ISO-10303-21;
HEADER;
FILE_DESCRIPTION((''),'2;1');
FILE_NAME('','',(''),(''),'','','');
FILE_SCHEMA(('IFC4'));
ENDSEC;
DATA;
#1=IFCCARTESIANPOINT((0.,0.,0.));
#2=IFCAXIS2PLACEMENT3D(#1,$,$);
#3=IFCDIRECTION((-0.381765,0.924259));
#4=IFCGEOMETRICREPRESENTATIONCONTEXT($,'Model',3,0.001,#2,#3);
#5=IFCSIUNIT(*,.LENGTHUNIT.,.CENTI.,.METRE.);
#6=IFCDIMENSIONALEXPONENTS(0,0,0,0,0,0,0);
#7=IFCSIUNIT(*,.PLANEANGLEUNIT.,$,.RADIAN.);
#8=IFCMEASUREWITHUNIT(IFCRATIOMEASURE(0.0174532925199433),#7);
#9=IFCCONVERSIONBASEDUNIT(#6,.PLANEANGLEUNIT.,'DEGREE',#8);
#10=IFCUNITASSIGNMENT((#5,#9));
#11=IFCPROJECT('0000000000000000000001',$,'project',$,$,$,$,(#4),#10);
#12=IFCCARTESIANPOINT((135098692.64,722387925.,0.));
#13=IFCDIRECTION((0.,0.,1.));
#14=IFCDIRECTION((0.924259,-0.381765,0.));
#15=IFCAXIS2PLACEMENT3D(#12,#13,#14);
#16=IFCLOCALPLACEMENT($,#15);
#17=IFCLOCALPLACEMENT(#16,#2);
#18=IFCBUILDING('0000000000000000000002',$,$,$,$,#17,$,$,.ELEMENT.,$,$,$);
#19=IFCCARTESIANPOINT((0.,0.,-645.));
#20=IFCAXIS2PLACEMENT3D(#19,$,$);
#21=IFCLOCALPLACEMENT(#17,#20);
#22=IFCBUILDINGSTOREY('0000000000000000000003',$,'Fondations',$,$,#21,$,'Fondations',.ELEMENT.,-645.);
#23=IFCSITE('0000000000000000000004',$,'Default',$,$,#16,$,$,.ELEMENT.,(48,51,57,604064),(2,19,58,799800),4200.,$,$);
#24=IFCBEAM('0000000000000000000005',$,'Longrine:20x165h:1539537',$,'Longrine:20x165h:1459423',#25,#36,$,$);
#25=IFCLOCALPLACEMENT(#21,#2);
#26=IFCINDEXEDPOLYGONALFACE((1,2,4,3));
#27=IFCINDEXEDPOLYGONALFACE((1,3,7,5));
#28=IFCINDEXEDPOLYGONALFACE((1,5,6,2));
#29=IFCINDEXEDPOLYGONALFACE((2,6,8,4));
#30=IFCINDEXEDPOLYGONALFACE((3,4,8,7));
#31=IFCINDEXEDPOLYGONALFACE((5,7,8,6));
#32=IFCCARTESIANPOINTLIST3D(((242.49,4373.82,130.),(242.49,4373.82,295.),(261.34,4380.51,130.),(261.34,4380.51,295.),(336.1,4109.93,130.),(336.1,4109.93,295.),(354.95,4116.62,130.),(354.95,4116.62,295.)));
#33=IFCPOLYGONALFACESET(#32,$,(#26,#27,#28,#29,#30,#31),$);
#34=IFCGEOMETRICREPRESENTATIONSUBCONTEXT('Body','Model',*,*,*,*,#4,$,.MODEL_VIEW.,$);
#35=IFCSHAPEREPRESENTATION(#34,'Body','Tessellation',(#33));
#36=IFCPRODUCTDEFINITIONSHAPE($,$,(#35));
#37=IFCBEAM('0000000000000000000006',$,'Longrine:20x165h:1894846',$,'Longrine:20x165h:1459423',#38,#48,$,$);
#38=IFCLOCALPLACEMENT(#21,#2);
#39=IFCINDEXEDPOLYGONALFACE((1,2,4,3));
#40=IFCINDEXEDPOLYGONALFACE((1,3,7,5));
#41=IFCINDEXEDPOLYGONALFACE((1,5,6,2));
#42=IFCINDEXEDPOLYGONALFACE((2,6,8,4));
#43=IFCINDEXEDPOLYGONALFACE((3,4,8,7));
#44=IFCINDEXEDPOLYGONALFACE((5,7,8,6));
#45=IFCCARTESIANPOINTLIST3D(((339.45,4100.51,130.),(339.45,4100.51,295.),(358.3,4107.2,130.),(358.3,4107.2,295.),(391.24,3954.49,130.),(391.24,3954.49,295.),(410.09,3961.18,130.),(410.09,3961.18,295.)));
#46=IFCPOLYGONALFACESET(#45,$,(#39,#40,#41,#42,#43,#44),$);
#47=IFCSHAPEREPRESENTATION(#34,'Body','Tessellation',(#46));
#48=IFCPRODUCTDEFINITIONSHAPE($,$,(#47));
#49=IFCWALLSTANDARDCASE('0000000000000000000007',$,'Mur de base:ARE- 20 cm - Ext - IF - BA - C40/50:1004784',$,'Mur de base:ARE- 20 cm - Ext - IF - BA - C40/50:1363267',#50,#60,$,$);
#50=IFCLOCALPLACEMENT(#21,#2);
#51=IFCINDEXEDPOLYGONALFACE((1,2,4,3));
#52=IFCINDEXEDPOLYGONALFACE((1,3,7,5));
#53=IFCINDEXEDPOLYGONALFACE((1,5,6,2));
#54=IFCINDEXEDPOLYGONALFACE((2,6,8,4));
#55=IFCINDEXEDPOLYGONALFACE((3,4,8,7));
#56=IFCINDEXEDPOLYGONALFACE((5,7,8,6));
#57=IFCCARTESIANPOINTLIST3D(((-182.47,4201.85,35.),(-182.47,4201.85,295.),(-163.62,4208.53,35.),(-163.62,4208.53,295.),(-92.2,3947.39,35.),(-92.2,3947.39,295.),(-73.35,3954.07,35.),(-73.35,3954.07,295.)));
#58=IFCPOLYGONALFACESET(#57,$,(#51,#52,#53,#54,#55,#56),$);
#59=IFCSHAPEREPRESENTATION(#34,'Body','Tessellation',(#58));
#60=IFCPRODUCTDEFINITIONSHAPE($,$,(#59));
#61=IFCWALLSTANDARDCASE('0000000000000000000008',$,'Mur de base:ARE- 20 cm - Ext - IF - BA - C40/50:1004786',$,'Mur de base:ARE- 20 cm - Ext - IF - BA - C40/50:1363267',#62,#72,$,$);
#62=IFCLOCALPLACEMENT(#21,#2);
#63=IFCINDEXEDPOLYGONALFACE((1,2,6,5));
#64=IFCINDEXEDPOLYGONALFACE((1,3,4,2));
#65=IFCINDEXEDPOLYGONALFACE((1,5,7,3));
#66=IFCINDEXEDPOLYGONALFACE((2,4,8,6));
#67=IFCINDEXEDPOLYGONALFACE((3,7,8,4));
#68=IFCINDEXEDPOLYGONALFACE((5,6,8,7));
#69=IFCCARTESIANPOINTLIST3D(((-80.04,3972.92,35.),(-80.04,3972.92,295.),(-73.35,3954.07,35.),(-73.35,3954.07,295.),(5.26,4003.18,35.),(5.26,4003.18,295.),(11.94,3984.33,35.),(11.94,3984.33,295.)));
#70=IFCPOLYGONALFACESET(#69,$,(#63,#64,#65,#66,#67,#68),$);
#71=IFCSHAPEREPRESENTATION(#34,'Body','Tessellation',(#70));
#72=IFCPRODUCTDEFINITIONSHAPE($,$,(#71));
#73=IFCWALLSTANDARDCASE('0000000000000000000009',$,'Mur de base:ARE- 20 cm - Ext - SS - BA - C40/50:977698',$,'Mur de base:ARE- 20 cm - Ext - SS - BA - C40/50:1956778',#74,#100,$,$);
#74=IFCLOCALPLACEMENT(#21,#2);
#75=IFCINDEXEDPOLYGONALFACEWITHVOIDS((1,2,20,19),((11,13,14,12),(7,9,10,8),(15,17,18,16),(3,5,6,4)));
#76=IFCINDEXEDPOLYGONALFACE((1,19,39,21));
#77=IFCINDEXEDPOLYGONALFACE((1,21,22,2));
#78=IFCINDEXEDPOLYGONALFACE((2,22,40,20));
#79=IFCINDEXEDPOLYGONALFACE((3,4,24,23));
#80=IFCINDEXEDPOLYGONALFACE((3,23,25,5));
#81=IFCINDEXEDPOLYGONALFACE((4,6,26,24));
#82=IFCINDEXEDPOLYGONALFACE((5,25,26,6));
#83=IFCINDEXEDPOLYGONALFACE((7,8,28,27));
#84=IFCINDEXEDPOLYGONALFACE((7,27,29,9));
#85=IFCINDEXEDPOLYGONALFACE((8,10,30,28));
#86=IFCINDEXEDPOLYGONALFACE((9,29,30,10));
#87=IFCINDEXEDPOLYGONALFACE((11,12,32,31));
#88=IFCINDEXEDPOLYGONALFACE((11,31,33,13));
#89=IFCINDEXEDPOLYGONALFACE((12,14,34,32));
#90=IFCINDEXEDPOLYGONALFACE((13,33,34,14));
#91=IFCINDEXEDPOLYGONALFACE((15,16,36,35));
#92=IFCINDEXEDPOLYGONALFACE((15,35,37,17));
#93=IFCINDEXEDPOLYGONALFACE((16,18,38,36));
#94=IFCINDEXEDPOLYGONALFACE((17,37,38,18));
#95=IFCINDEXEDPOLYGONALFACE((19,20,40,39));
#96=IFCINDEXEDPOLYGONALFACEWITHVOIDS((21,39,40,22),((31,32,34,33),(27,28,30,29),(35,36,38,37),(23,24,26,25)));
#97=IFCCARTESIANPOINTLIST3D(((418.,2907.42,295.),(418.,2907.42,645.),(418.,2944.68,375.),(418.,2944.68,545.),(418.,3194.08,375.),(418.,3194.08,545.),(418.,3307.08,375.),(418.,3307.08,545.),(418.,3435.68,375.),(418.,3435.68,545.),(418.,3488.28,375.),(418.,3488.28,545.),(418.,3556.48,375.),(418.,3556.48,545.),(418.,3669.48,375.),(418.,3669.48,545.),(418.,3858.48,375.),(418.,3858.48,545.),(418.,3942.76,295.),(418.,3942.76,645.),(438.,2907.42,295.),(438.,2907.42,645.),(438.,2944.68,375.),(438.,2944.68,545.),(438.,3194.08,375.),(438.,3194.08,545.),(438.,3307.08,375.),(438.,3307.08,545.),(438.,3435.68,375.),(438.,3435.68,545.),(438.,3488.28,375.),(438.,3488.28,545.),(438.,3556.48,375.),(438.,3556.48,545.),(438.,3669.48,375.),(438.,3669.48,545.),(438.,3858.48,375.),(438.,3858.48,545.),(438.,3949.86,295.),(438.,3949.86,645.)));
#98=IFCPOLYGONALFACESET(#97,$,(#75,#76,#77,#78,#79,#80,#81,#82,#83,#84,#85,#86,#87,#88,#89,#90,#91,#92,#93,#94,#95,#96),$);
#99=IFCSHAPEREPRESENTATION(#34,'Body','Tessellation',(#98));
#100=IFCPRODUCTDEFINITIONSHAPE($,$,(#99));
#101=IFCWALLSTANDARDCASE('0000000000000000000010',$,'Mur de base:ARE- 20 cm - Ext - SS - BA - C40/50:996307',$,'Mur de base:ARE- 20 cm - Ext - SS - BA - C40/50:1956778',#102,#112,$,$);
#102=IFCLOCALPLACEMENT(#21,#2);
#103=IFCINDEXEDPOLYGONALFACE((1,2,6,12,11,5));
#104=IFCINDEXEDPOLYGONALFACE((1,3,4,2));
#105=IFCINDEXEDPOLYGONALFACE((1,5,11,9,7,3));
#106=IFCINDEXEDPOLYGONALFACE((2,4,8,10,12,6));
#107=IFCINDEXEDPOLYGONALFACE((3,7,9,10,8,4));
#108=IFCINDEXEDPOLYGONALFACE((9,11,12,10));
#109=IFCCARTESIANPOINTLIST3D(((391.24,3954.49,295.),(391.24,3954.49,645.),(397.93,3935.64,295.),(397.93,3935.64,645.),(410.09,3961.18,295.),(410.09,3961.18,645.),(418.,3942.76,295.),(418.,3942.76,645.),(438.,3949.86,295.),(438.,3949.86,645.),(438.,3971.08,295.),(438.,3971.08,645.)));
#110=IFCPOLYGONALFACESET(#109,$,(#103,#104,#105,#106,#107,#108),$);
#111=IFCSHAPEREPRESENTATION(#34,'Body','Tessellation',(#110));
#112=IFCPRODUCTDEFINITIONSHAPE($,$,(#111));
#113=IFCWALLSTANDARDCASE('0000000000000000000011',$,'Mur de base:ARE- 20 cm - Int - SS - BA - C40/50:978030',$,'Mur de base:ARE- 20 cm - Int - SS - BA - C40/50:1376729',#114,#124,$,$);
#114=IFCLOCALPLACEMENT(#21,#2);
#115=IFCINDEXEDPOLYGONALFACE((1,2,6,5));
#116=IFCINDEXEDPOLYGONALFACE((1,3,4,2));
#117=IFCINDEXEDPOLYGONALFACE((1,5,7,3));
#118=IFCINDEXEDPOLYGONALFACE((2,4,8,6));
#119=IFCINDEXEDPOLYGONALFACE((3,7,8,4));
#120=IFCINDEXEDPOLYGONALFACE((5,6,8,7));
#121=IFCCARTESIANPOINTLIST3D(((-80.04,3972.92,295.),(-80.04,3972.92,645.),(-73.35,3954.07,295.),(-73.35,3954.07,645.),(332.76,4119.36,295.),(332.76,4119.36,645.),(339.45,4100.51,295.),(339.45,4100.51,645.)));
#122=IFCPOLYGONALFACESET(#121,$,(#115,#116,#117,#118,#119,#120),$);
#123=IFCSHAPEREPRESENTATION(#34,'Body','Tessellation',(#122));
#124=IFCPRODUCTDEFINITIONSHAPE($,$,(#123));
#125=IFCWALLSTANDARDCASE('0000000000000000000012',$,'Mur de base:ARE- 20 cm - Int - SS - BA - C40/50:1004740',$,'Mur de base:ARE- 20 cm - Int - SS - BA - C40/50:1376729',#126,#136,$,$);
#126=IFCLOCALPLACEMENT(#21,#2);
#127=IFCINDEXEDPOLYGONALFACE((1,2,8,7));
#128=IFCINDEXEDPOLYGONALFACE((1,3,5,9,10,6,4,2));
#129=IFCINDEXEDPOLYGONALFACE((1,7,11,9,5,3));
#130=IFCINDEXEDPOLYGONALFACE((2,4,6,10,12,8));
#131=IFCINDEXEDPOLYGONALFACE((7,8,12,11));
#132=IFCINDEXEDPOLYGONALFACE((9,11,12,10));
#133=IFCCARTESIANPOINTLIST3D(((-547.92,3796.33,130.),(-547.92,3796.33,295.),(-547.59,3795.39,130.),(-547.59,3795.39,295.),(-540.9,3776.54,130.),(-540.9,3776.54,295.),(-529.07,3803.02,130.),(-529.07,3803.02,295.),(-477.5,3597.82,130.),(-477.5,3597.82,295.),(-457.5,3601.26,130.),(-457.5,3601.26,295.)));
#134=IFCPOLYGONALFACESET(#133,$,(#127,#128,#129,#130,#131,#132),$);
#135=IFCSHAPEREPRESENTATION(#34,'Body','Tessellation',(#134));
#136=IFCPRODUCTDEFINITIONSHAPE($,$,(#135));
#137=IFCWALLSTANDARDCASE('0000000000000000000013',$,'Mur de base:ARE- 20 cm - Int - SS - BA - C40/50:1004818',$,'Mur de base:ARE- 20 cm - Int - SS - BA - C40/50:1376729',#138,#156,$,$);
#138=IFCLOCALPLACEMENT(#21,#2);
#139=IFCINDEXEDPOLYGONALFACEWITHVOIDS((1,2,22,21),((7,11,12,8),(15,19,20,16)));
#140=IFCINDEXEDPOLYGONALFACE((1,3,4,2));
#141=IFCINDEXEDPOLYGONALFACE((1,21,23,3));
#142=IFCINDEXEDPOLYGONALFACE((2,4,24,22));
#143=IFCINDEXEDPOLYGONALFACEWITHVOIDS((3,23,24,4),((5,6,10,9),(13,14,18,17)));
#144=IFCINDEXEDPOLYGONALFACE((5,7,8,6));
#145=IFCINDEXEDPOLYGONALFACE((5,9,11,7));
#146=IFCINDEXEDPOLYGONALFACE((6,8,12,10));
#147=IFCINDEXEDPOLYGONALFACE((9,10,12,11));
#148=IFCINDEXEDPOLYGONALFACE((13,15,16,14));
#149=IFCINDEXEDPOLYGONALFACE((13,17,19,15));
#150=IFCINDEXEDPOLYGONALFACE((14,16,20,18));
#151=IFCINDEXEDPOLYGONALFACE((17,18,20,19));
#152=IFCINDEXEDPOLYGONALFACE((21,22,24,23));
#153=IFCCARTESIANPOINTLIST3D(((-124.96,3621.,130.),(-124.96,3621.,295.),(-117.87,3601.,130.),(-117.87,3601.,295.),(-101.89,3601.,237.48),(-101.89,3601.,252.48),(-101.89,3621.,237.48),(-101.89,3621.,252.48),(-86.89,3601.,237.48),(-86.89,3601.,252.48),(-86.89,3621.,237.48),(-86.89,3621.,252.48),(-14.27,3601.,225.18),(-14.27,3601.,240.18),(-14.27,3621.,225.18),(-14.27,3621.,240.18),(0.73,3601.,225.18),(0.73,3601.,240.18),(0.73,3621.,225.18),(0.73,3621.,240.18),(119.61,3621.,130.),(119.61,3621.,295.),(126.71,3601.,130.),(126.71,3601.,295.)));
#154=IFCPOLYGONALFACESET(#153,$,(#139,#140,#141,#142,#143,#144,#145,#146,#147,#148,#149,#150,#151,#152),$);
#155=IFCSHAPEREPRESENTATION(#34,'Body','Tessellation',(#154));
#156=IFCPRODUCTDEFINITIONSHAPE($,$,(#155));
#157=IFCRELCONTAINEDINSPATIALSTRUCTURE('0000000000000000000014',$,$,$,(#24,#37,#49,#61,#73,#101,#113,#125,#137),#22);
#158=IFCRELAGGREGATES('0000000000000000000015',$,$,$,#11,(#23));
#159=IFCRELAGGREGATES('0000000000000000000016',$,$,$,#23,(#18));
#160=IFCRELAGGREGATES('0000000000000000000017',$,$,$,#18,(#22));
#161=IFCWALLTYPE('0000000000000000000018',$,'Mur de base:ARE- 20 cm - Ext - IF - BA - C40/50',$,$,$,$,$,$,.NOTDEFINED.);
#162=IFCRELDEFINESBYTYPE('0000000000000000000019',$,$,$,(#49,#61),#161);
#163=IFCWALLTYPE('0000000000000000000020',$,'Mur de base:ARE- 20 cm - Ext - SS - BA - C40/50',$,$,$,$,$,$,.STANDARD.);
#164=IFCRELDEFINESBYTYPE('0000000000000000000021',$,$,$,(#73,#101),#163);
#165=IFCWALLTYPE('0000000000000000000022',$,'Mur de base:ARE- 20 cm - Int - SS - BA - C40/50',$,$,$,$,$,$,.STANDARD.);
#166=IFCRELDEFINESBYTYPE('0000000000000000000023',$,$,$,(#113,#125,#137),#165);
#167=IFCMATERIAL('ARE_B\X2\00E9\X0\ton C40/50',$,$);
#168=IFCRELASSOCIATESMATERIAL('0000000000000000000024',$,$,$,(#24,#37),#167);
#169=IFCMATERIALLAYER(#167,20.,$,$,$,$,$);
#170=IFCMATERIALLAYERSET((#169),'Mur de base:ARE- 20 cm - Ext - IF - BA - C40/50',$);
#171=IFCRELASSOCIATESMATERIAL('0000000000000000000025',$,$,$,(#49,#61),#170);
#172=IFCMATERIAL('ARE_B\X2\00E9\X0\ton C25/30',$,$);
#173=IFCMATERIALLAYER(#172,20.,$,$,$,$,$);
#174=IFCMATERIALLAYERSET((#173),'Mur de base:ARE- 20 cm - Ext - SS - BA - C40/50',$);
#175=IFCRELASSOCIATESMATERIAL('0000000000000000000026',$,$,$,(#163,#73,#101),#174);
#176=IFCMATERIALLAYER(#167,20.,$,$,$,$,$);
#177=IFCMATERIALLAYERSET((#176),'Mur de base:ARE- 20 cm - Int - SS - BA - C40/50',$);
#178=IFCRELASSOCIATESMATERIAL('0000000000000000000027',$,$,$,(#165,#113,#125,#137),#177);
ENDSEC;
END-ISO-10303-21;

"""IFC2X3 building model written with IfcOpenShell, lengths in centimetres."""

from ifc_helpers import new_model, entity, si_unit, converted_unit, direction, frame, frame_2d, origin, place, context, subcontext, project, spatial, polyline, rectangle, outline, extrude, material, layer, layer_set, layer_usage, type_object, element, save


model = new_model("IFC2X3")

# Units and contexts
model_context = context("Model", 3, precision=0.001, world=origin(), true_north=direction((-0.381765, 0.924259)))
body_context = subcontext(model_context, "Body", "Model", "MODEL_VIEW")
ifc_project = project(units=[si_unit("LENGTHUNIT", "METRE", prefix="CENTI"), converted_unit("PLANEANGLEUNIT", "DEGREE", entity("IfcRatioMeasure", 0.0174532925199433), si_unit("PLANEANGLEUNIT", "RADIAN"), dimensions=[0, 0, 0, 0, 0, 0, 0])], contexts=[model_context])

# Site, building, storey
site_placement = place(None, frame((135098692.64, 722387925.0, 0.0), z_axis=(0.0, 0.0, 1.0), x_axis=(0.924259, -0.381765, 0.0)))
site = spatial("IfcSite", under=ifc_project, at=site_placement, Name="Default", CompositionType="ELEMENT", RefLatitude=(48, 51, 57, 604064), RefLongitude=(2, 19, 58, 799800), RefElevation=4200.0)
building_placement = place(site_placement, origin())
building = spatial("IfcBuilding", under=site, at=building_placement, CompositionType="ELEMENT")
storey_placement = place(building_placement, frame((0.0, 0.0, -645.0)))
storey = spatial("IfcBuildingStorey", under=building, at=storey_placement, Name="Fondations", LongName="Fondations", CompositionType="ELEMENT", Elevation=-645.0)

# Beams
ifc_material_1 = material(Name="ARE_Béton C40/50")
beam_1_placement = place(storey_placement, frame((345.53, 4113.28, 295.0), z_axis=(0.0, 0.0, 1.0), x_axis=(-0.334331, 0.942456, 0.0)))
element("IfcBeam", 1, at=beam_1_placement, inside=storey, material=ifc_material_1, Name="Longrine:20x165h:1539537", ObjectType="Longrine:20x165h:1459423", context=body_context, shape_type="SweptSolid", body=[
    extrude(rectangle(XDim=165.0, YDim=20.0, at=frame_2d((0.0, 0.0), x_axis=(1.0, 0.0))), frame((0.0, 0.0, -82.5), z_axis=(1.0, 0.0, 0.0), x_axis=(0.0, 0.0, -1.0)), (0.0, 0.0, 1.0), 280.0),
])
beam_2_placement = place(storey_placement, frame((345.53, 4113.28, 295.0), z_axis=(0.0, 0.0, 1.0), x_axis=(0.334331, -0.942456, 0.0)))
element("IfcBeam", 2, at=beam_2_placement, inside=storey, material=ifc_material_1, Name="Longrine:20x165h:1894846", ObjectType="Longrine:20x165h:1459423", context=body_context, shape_type="SweptSolid", body=[
    extrude(rectangle(XDim=165.0, YDim=20.0, at=frame_2d((0.0, 0.0), x_axis=(1.0, 0.0))), frame((10.0, 0.0, -82.5), z_axis=(1.0, 0.0, 0.0), x_axis=(0.0, 0.0, -1.0)), (0.0, 0.0, 1.0), 154.93),
])

# Walls
ifc_layer_1 = layer(ifc_material_1, 20.0)
ifc_layer_set_1 = layer_set([ifc_layer_1], Name="Mur de base:ARE- 20 cm - Ext - IF - BA - C40/50")
ifc_layer_usage_1 = layer_usage(ifc_layer_set_1, "AXIS2", "NEGATIVE", 10.0)
wall_type_1 = type_object("IfcWallType", Name="Mur de base:ARE- 20 cm - Ext - IF - BA - C40/50", PredefinedType="NOTDEFINED")
wall_1_placement = place(storey_placement, frame((-82.77, 3950.73, 35.0), z_axis=(0.0, 0.0, 1.0), x_axis=(-0.334331, 0.942456, 0.0)))
element("IfcWallStandardCase", 3, at=wall_1_placement, inside=storey, type_object=wall_type_1, material=ifc_layer_usage_1, Name="Mur de base:ARE- 20 cm - Ext - IF - BA - C40/50:1004784", ObjectType="Mur de base:ARE- 20 cm - Ext - IF - BA - C40/50:1363267", context=body_context, shape_type="SweptSolid", body=[
    extrude(rectangle(XDim=270.0, YDim=20.0, at=frame_2d((135.0, 0.0), x_axis=(-1.0, 0.0))), origin(), (0.0, 0.0, 1.0), 260.0),
])
ifc_layer_usage_2 = layer_usage(ifc_layer_set_1, "AXIS2", "NEGATIVE", 10.0)
wall_2_placement = place(storey_placement, frame((8.6, 3993.75, 35.0), z_axis=(0.0, 0.0, 1.0), x_axis=(-0.942456, -0.334331, 0.0)))
element("IfcWallStandardCase", 4, at=wall_2_placement, inside=storey, type_object=wall_type_1, material=ifc_layer_usage_2, Name="Mur de base:ARE- 20 cm - Ext - IF - BA - C40/50:1004786", ObjectType="Mur de base:ARE- 20 cm - Ext - IF - BA - C40/50:1363267", context=body_context, shape_type="SweptSolid", body=[
    extrude(rectangle(XDim=90.5, YDim=20.0, at=frame_2d((45.25, 0.0), x_axis=(-1.0, 0.0))), origin(), (0.0, 0.0, 1.0), 260.0),
])

# Wall, openings
ifc_material_2 = material(Name="ARE_Béton C25/30")
ifc_layer_2 = layer(ifc_material_2, 20.0)
ifc_layer_set_2 = layer_set([ifc_layer_2], Name="Mur de base:ARE- 20 cm - Ext - SS - BA - C40/50")
ifc_layer_usage_3 = layer_usage(ifc_layer_set_2, "AXIS2", "NEGATIVE", 10.0)
wall_type_2 = type_object("IfcWallType", Name="Mur de base:ARE- 20 cm - Ext - SS - BA - C40/50", PredefinedType="STANDARD", material=ifc_layer_set_2)
wall_3_placement = place(storey_placement, frame((428.0, 3949.86, 295.0), z_axis=(0.0, 0.0, 1.0), x_axis=(0.0, -1.0, 0.0)))
wall_3 = element("IfcWallStandardCase", 5, at=wall_3_placement, inside=storey, type_object=wall_type_2, material=ifc_layer_usage_3, Name="Mur de base:ARE- 20 cm - Ext - SS - BA - C40/50:977698", ObjectType="Mur de base:ARE- 20 cm - Ext - SS - BA - C40/50:1956778", context=body_context, shape_type="SweptSolid", body=[
    extrude(outline(polyline([(1042.44, -10.0), (1042.44, 10.0), (0.0, 10.0), (7.09, -10.0), (1042.44, -10.0)])), origin(), (0.0, 0.0, 1.0), 350.0),
])
opening_1_placement = place(wall_3_placement, frame((3949.86, -428.0, -295.0), z_axis=(0.0, 0.0, 1.0), x_axis=(0.0, 1.0, 0.0)))
element("IfcOpeningElement", 6, at=opening_1_placement, cuts=wall_3, ObjectType="Opening", context=body_context, shape_type="SweptSolid", body=[
    extrude(rectangle(XDim=170.0, YDim=249.4, at=frame_2d((0.0, 0.0), x_axis=(1.0, 0.0))), frame((285.6, 3069.38, 460.0), z_axis=(1.0, 0.0, 0.0), x_axis=(0.0, 0.0, -1.0)), (0.0, 0.0, 1.0), 304.8),
])
opening_2_placement = place(wall_3_placement, frame((3949.86, -428.0, -295.0), z_axis=(0.0, 0.0, 1.0), x_axis=(0.0, 1.0, 0.0)))
element("IfcOpeningElement", 7, at=opening_2_placement, cuts=wall_3, ObjectType="Opening", context=body_context, shape_type="SweptSolid", body=[
    extrude(rectangle(XDim=170.0, YDim=128.6, at=frame_2d((0.0, 0.0), x_axis=(0.0, 1.0))), frame((265.6, 3371.38, 460.0), z_axis=(1.0, 0.0, 0.0), x_axis=(0.0, -1.0, 0.0)), (0.0, 0.0, 1.0), 304.8),
])
opening_3_placement = place(wall_3_placement, frame((3949.86, -428.0, -295.0), z_axis=(0.0, 0.0, 1.0), x_axis=(0.0, 1.0, 0.0)))
element("IfcOpeningElement", 8, at=opening_3_placement, cuts=wall_3, ObjectType="Opening", context=body_context, shape_type="SweptSolid", body=[
    extrude(rectangle(XDim=170.0, YDim=68.2, at=frame_2d((0.0, 0.0), x_axis=(0.0, 1.0))), frame((265.6, 3522.38, 460.0), z_axis=(1.0, 0.0, 0.0), x_axis=(0.0, -1.0, 0.0)), (0.0, 0.0, 1.0), 304.8),
])
opening_4_placement = place(wall_3_placement, frame((3949.86, -428.0, -295.0), z_axis=(0.0, 0.0, 1.0), x_axis=(0.0, 1.0, 0.0)))
element("IfcOpeningElement", 9, at=opening_4_placement, cuts=wall_3, ObjectType="Opening", context=body_context, shape_type="SweptSolid", body=[
    extrude(rectangle(XDim=170.0, YDim=189.0, at=frame_2d((0.0, 0.0), x_axis=(1.0, 0.0))), frame((285.6, 3763.98, 460.0), z_axis=(1.0, 0.0, 0.0), x_axis=(0.0, 0.0, -1.0)), (0.0, 0.0, 1.0), 304.8),
])

# Walls
ifc_layer_usage_4 = layer_usage(ifc_layer_set_2, "AXIS2", "NEGATIVE", 10.0)
wall_4_placement = place(storey_placement, frame((394.59, 3945.07, 295.0), z_axis=(0.0, 0.0, 1.0), x_axis=(0.942456, 0.334331, 0.0)))
element("IfcWallStandardCase", 10, at=wall_4_placement, inside=storey, type_object=wall_type_2, material=ifc_layer_usage_4, Name="Mur de base:ARE- 20 cm - Ext - SS - BA - C40/50:996307", ObjectType="Mur de base:ARE- 20 cm - Ext - SS - BA - C40/50:1956778", context=body_context, shape_type="SweptSolid", body=[
    extrude(outline(polyline([(42.52, -10.0), (49.61, 10.0), (20.0, 10.0), (0.0, 10.0), (0.0, -10.0), (21.29, -10.0), (42.52, -10.0)])), origin(), (0.0, 0.0, 1.0), 350.0),
])
ifc_layer_3 = layer(ifc_material_1, 20.0)
ifc_layer_set_3 = layer_set([ifc_layer_3], Name="Mur de base:ARE- 20 cm - Int - SS - BA - C40/50")
ifc_layer_usage_5 = layer_usage(ifc_layer_set_3, "AXIS2", "NEGATIVE", 10.0)
wall_type_3 = type_object("IfcWallType", Name="Mur de base:ARE- 20 cm - Int - SS - BA - C40/50", PredefinedType="STANDARD", material=ifc_layer_set_3)
wall_5_placement = place(storey_placement, frame((-76.69, 3963.5, 295.0), z_axis=(0.0, 0.0, 1.0), x_axis=(0.942456, 0.334331, 0.0)))
element("IfcWallStandardCase", 11, at=wall_5_placement, inside=storey, type_object=wall_type_3, material=ifc_layer_usage_5, Name="Mur de base:ARE- 20 cm - Int - SS - BA - C40/50:978030", ObjectType="Mur de base:ARE- 20 cm - Int - SS - BA - C40/50:1376729", context=body_context, shape_type="SweptSolid", body=[
    extrude(rectangle(XDim=438.0, YDim=20.0, at=frame_2d((219.0, 0.0), x_axis=(-1.0, 0.0))), origin(), (0.0, 0.0, 1.0), 350.0),
])
ifc_layer_usage_6 = layer_usage(ifc_layer_set_3, "AXIS2", "NEGATIVE", 10.0)
wall_6_placement = place(storey_placement, frame((-466.92, 3597.92, 130.0), z_axis=(0.0, 0.0, 1.0), x_axis=(-0.334331, 0.942456, 0.0)))
element("IfcWallStandardCase", 12, at=wall_6_placement, inside=storey, type_object=wall_type_3, material=ifc_layer_usage_6, Name="Mur de base:ARE- 20 cm - Int - SS - BA - C40/50:1004740", ObjectType="Mur de base:ARE- 20 cm - Int - SS - BA - C40/50:1376729", context=body_context, shape_type="SweptSolid", body=[
    extrude(outline(polyline([(214.07, -10.0), (214.07, 10.0), (213.07, 10.0), (193.07, 10.0), (3.44, 10.0), (0.0, -10.0), (214.07, -10.0)])), origin(), (0.0, 0.0, 1.0), 165.0),
])

# Wall, openings
ifc_layer_usage_7 = layer_usage(ifc_layer_set_3, "AXIS2", "NEGATIVE", 10.0)
wall_7_placement = place(storey_placement, frame((-124.96, 3611.0, 130.0)))
wall_7 = element("IfcWallStandardCase", 13, at=wall_7_placement, inside=storey, type_object=wall_type_3, material=ifc_layer_usage_7, Name="Mur de base:ARE- 20 cm - Int - SS - BA - C40/50:1004818", ObjectType="Mur de base:ARE- 20 cm - Int - SS - BA - C40/50:1376729", context=body_context, shape_type="SweptSolid", body=[
    extrude(outline(polyline([(251.67, -10.0), (244.57, 10.0), (0.0, 10.0), (7.09, -10.0), (251.67, -10.0)])), origin(), (0.0, 0.0, 1.0), 165.0),
])
opening_5_placement = place(wall_7_placement, origin())
element("IfcOpeningElement", 14, at=opening_5_placement, cuts=wall_7, ObjectType="Opening", context=body_context, shape_type="SweptSolid", body=[
    extrude(rectangle(XDim=15.0, YDim=15.0, at=frame_2d((0.0, 0.0), x_axis=(0.0, 1.0))), frame((30.57, -10.0, 114.98), z_axis=(0.0, 1.0, 0.0), x_axis=(1.0, 0.0, 0.0)), (0.0, 0.0, 1.0), 20.0),
])
opening_6_placement = place(wall_7_placement, origin())
element("IfcOpeningElement", 15, at=opening_6_placement, cuts=wall_7, ObjectType="Opening", context=body_context, shape_type="SweptSolid", body=[
    extrude(rectangle(XDim=15.0, YDim=15.0, at=frame_2d((0.0, 0.0), x_axis=(0.0, 1.0))), frame((118.19, -10.0, 102.68), z_axis=(0.0, 1.0, 0.0), x_axis=(1.0, 0.0, 0.0)), (0.0, 0.0, 1.0), 20.0),
])

save(model, "model.ifc")
